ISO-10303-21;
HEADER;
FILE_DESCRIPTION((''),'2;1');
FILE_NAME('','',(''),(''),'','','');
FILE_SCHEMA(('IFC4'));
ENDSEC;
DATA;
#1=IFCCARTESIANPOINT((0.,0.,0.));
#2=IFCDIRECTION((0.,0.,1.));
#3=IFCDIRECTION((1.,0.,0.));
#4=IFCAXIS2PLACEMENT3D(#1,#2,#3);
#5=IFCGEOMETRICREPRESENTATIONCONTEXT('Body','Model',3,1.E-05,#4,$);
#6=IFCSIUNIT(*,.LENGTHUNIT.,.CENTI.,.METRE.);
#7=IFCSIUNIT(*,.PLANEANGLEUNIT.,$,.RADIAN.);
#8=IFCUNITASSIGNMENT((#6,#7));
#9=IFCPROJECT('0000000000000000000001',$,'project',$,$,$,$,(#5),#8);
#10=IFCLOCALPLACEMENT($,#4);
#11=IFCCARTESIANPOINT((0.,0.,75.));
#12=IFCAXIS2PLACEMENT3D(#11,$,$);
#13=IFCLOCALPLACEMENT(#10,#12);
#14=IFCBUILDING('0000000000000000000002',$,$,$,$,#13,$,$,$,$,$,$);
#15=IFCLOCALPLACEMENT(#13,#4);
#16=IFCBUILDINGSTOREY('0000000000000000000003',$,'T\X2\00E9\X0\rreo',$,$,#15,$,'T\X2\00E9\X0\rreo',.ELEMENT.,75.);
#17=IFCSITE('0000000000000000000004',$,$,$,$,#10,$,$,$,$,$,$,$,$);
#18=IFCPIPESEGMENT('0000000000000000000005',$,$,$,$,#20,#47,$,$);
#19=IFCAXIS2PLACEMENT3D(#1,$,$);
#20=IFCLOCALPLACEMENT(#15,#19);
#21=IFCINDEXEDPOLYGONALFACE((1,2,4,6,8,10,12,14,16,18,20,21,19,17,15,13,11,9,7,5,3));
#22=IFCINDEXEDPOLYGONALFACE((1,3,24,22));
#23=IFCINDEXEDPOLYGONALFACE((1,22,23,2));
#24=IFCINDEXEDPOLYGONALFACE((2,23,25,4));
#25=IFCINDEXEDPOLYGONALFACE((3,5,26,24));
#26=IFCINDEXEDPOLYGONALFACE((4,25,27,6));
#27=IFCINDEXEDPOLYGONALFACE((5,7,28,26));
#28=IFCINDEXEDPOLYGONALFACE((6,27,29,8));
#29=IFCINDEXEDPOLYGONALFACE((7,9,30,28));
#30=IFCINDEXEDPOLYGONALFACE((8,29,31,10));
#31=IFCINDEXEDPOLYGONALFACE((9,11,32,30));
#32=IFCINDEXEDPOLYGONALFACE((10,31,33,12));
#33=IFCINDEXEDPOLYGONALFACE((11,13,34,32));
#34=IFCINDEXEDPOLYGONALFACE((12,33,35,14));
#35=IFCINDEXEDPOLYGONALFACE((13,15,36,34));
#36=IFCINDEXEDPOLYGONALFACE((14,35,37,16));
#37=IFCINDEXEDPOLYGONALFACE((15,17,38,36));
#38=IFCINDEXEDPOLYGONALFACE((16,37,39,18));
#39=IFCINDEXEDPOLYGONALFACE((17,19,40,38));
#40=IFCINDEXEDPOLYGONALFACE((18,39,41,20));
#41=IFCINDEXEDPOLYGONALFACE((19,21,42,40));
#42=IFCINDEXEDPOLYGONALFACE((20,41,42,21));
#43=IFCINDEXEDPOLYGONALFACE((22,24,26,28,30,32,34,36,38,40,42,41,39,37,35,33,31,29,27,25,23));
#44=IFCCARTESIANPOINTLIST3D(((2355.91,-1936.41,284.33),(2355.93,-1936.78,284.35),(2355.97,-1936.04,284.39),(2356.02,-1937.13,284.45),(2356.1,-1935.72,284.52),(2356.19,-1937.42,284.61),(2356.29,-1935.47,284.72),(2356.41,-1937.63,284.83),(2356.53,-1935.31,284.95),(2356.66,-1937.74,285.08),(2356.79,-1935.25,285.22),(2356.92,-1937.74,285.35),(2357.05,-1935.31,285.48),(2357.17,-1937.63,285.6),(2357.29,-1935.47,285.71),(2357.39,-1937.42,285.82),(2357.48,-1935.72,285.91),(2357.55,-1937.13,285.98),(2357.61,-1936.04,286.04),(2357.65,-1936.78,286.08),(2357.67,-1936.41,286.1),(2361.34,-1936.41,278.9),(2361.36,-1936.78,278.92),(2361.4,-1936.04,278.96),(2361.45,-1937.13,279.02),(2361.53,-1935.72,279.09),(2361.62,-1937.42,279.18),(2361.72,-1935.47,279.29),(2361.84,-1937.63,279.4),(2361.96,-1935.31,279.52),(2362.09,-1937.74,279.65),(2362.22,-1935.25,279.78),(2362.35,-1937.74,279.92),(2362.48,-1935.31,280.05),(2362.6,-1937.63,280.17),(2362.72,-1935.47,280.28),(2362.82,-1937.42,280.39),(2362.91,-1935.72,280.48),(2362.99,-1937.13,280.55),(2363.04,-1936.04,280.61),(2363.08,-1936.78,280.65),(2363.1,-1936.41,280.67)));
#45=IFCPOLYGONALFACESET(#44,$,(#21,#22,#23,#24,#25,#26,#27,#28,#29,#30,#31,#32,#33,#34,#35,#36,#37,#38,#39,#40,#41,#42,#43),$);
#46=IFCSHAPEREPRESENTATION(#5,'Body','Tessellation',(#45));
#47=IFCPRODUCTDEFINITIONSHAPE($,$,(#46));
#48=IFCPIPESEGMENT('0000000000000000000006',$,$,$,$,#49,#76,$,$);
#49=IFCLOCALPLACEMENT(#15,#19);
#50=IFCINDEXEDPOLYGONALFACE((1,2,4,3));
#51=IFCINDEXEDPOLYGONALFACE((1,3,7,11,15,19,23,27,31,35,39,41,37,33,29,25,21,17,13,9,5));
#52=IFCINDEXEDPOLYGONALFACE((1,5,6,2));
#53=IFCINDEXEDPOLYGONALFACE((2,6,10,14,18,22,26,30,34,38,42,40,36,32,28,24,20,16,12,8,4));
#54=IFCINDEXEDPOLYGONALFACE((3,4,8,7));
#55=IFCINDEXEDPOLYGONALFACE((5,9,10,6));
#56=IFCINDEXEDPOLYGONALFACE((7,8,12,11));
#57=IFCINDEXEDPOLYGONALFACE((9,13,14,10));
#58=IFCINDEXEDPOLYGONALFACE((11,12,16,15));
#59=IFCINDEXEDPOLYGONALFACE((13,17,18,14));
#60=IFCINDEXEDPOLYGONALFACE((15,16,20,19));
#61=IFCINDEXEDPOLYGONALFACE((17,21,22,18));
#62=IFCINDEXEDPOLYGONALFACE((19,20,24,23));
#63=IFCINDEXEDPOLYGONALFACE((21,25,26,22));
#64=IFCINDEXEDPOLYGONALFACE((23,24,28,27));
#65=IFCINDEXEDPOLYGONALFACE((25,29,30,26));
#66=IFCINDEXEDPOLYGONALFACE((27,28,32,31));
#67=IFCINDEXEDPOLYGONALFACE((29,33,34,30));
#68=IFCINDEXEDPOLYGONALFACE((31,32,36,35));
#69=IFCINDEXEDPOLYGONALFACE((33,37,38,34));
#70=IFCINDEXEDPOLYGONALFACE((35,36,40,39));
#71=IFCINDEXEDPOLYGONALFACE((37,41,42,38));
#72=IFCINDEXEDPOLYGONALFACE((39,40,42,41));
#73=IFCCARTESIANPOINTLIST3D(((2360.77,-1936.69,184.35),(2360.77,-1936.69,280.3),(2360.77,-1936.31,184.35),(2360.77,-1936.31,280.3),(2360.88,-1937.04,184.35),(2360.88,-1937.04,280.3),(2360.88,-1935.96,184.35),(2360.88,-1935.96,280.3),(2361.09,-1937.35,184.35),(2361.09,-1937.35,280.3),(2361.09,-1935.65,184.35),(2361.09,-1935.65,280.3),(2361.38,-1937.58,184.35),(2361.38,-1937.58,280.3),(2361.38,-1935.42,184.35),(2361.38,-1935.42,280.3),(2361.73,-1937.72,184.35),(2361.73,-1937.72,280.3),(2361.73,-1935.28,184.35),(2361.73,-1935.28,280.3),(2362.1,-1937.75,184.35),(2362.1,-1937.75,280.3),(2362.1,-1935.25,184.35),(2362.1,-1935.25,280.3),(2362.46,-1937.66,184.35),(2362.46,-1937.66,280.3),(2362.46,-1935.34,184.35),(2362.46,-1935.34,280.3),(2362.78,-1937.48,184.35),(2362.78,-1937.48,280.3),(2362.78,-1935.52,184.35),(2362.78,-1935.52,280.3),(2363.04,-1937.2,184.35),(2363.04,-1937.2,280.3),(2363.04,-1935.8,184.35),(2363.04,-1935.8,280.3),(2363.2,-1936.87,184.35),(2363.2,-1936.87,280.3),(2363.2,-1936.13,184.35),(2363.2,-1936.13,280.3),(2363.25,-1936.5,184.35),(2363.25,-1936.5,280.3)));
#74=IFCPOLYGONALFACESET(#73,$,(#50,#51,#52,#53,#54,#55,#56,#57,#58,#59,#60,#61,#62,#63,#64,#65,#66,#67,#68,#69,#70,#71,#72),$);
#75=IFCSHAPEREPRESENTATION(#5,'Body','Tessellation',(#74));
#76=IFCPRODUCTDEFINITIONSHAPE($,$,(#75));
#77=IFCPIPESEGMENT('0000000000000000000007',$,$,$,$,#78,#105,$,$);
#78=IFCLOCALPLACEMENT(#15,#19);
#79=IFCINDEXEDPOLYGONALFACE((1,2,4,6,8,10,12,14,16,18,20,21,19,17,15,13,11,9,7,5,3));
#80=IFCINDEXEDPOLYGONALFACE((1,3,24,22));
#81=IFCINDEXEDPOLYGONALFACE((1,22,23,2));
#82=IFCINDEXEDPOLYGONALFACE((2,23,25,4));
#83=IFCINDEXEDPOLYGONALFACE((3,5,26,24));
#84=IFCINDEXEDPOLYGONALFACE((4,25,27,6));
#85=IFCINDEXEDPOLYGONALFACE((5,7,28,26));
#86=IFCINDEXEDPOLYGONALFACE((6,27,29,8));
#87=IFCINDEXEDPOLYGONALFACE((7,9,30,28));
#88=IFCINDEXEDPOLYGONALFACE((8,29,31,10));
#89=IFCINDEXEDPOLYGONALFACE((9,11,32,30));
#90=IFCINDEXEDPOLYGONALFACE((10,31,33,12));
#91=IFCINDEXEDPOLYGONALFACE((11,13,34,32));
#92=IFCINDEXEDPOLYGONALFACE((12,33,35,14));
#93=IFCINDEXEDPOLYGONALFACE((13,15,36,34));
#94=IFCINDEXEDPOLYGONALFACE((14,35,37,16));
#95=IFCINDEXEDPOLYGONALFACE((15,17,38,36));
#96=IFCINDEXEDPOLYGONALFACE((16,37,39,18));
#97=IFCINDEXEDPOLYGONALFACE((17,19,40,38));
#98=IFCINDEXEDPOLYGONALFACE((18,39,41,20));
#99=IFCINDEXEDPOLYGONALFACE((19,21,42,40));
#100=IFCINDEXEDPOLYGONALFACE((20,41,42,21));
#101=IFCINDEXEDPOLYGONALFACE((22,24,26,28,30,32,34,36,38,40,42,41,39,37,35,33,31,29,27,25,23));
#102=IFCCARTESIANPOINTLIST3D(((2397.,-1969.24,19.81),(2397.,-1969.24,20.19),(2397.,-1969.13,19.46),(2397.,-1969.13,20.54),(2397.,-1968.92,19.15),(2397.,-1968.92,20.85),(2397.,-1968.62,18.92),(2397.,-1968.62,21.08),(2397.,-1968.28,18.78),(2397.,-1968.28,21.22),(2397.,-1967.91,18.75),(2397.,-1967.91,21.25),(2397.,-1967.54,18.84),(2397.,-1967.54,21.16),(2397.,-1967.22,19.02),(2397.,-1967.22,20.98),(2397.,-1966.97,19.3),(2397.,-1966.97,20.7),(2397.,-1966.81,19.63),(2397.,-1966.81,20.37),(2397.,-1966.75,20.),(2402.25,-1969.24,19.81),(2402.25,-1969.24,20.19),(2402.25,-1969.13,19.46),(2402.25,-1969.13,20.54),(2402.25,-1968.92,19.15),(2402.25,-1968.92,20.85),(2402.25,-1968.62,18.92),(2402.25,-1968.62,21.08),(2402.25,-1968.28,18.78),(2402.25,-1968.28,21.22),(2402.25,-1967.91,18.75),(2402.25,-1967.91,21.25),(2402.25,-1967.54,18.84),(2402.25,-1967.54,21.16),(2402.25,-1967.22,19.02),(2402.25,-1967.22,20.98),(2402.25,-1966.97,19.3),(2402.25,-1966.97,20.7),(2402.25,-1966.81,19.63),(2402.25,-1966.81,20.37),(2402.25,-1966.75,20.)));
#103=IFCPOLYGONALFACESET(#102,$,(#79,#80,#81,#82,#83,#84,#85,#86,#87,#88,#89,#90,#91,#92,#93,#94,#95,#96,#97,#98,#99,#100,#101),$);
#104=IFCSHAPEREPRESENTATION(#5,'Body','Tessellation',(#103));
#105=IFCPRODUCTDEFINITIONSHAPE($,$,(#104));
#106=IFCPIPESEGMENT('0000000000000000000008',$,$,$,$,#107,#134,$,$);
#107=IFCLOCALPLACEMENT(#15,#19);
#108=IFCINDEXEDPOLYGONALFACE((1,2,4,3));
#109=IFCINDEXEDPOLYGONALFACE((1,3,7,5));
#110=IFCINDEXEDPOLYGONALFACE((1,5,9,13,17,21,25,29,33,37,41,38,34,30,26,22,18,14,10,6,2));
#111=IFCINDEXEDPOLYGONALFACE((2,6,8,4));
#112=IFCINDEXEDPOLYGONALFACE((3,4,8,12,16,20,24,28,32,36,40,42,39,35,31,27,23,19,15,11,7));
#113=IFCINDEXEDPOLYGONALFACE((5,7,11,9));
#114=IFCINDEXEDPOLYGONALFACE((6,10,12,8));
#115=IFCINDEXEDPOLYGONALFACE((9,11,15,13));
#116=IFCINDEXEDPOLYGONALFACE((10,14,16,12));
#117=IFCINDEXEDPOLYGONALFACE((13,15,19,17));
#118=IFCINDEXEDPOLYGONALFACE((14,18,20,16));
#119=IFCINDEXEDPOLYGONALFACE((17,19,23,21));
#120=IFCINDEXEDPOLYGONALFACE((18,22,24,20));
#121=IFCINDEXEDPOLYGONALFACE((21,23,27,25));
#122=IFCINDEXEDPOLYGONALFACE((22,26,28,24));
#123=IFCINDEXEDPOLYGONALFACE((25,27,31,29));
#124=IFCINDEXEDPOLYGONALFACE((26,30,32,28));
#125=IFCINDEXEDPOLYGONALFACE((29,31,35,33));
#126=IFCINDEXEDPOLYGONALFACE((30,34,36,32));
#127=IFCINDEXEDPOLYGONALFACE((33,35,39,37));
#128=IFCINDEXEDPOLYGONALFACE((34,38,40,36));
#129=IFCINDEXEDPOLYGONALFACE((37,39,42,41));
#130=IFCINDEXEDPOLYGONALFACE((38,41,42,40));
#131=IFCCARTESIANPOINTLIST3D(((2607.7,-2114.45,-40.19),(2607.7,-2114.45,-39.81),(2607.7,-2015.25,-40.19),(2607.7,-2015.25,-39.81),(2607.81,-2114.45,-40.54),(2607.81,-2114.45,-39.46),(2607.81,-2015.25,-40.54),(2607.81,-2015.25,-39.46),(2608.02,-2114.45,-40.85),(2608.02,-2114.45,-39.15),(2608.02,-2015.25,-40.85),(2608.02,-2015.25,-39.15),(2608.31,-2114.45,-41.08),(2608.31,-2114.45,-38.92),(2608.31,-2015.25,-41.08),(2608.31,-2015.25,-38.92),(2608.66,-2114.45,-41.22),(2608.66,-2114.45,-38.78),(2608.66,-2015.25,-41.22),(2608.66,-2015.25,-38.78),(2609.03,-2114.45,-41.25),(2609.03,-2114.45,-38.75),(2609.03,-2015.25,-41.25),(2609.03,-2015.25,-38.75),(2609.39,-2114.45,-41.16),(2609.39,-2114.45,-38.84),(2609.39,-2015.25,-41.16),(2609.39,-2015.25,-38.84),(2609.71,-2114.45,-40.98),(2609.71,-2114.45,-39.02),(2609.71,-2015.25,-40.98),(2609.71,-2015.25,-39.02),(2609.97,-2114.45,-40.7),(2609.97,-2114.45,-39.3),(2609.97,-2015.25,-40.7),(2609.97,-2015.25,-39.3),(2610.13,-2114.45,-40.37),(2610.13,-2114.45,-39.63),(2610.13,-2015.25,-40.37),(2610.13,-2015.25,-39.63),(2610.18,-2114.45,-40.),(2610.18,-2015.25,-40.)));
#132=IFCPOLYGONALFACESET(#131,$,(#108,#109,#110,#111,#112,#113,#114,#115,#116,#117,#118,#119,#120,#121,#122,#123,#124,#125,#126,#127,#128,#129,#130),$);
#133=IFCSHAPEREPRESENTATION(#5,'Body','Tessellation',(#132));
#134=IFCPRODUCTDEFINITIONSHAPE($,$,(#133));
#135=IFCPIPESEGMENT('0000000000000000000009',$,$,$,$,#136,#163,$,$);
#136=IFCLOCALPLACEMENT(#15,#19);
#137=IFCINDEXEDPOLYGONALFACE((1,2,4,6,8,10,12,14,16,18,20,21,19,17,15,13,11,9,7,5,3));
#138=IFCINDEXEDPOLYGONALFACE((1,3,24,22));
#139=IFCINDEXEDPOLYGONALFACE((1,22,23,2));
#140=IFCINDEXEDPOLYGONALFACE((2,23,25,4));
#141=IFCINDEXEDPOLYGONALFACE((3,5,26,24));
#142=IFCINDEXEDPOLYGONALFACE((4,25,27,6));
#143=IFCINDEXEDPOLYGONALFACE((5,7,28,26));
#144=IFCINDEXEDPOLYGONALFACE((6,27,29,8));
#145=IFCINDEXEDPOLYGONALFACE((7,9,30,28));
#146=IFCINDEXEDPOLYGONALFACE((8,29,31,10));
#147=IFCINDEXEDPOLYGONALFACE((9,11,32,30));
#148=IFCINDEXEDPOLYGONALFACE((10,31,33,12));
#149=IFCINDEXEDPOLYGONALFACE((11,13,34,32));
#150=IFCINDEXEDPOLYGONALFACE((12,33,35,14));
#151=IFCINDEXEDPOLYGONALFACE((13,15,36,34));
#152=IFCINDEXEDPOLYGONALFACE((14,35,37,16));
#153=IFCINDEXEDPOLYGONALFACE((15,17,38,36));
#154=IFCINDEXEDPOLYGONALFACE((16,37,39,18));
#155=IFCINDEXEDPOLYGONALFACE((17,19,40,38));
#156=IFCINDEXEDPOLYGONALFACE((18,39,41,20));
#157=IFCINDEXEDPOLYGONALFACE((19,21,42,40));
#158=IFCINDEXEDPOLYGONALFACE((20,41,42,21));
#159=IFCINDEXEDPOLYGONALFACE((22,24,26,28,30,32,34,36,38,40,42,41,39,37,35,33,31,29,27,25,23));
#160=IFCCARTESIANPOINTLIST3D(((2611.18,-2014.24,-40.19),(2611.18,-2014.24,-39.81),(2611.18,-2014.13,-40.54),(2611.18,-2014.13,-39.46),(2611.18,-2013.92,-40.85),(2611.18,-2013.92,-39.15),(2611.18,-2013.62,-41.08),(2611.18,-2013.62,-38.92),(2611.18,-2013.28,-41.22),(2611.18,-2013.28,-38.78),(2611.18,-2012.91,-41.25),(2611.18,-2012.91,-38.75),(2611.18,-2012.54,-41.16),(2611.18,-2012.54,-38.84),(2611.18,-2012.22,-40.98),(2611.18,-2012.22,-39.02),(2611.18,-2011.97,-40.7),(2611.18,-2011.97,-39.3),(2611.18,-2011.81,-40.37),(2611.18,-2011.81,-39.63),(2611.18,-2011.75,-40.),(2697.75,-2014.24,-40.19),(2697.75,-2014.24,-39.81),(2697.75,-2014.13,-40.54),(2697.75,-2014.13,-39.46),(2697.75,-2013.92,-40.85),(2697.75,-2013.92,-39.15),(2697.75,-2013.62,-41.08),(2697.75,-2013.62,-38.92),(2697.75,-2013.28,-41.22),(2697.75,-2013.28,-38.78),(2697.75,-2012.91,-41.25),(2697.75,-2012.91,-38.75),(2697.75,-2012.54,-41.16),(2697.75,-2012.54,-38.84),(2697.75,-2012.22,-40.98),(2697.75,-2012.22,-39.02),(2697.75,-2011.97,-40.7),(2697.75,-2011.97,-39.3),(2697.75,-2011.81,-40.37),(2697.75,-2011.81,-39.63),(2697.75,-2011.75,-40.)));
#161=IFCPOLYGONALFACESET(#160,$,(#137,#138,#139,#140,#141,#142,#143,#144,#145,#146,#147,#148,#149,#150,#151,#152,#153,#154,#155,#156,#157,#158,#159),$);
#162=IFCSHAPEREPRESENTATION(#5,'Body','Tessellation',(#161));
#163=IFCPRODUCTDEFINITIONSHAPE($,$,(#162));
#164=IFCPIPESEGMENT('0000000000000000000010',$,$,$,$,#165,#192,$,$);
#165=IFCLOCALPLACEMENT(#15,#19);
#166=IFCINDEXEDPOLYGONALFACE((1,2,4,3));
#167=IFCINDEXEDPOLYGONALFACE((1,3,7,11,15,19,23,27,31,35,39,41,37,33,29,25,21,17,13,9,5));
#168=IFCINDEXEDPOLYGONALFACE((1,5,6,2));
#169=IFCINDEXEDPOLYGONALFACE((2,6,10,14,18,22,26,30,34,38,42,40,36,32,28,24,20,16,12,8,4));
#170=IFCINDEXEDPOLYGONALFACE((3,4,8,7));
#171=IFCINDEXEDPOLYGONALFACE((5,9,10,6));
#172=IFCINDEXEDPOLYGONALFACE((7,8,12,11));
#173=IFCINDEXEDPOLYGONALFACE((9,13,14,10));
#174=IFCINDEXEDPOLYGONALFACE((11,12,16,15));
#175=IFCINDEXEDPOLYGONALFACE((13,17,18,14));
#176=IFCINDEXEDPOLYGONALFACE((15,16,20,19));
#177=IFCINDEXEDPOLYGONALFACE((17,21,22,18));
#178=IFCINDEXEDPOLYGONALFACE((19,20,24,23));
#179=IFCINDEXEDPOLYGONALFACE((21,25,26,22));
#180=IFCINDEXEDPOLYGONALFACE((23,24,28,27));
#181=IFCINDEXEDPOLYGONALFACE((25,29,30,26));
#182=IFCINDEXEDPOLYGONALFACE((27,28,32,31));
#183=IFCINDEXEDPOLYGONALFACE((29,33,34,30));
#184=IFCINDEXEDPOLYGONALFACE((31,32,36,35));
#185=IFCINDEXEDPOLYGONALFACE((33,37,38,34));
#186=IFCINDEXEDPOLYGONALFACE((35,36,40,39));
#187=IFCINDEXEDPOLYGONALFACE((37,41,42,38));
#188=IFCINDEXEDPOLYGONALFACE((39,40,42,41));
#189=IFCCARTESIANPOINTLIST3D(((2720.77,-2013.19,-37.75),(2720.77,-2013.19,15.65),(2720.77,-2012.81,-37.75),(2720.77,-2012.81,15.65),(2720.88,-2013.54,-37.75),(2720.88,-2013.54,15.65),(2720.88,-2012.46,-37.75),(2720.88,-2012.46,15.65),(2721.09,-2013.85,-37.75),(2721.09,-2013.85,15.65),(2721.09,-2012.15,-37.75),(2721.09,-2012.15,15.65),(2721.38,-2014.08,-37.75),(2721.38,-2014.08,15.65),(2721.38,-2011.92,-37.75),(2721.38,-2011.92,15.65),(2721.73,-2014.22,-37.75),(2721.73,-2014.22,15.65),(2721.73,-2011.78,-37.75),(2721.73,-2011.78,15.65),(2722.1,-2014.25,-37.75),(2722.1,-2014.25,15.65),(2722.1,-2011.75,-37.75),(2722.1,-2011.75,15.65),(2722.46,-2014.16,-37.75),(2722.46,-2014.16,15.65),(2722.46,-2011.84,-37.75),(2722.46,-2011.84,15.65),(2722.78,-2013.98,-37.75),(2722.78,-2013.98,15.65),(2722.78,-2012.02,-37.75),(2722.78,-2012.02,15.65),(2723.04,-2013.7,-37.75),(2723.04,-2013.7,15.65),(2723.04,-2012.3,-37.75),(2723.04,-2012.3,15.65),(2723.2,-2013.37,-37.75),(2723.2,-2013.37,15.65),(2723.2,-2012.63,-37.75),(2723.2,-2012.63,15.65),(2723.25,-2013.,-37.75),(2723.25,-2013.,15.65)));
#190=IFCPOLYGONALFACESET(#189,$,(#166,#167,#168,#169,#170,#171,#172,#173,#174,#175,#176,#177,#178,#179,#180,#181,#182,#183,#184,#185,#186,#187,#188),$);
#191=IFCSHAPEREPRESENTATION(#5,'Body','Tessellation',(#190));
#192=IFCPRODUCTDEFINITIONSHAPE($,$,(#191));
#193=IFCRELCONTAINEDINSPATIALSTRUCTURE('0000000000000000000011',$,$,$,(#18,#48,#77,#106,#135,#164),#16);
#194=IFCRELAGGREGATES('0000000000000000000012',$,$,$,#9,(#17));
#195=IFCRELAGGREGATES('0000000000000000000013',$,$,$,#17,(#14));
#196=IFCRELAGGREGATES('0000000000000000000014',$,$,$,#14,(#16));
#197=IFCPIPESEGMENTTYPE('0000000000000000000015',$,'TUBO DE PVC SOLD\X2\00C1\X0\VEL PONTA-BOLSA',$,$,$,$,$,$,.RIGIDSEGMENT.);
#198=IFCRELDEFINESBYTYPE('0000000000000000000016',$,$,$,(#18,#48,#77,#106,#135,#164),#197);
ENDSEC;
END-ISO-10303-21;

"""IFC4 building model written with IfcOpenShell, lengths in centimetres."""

from ifc_helpers import new_model, si_unit, frame, origin_with_axes, origin_2d_with_axis, place, context, project, spatial, circle, extrude, type_object, element, save


model = new_model("IFC4")

# Units and contexts
model_context = context("Model", 3, precision=1e-05, world=origin_with_axes(), identifier="Body")
ifc_project = project(units=[si_unit("LENGTHUNIT", "METRE", prefix="CENTI"), si_unit("PLANEANGLEUNIT", "RADIAN")], contexts=[model_context])

# Site, building, storey
site_placement = place(None, origin_with_axes())
site = spatial("IfcSite", under=ifc_project, at=site_placement)
building_placement = place(site_placement, frame((0.0, 0.0, 75.0)))
building = spatial("IfcBuilding", under=site, at=building_placement)
storey_placement = place(building_placement, origin_with_axes())
storey = spatial("IfcBuildingStorey", under=building, at=storey_placement, Name="Térreo", LongName="Térreo", CompositionType="ELEMENT", Elevation=75.0)

# Pipe segments
pipe_segment_type_1 = type_object("IfcPipeSegmentType", Name="TUBO DE PVC SOLDÁVEL PONTA-BOLSA", PredefinedType="RIGIDSEGMENT")
pipe_segment_1_placement = place(storey_placement, frame((2359.5, -1936.5, 286.1), z_axis=(0.0, 0.0, 1.0), x_axis=(1.0, 0.0, 0.0)))
element("IfcPipeSegment", 1, at=pipe_segment_1_placement, inside=storey, type_object=pipe_segment_type_1, context=model_context, shape_type="SolidModel", body=[
    extrude(circle(Radius=1.25, at=origin_2d_with_axis()), frame((-2.72, 0.0, -0.88), z_axis=(0.707107, 0.0, -0.707107), x_axis=(0.0, 1.0, 0.0)), (0.0, 0.0, 1.0), 7.68),
])
pipe_segment_2_placement = place(storey_placement, frame((2362.0, -1936.5, 280.3), z_axis=(0.0, 0.0, 1.0), x_axis=(1.0, 0.0, 0.0)))
element("IfcPipeSegment", 2, at=pipe_segment_2_placement, inside=storey, type_object=pipe_segment_type_1, context=model_context, shape_type="SolidModel", body=[
    extrude(circle(Radius=1.25, at=origin_2d_with_axis()), frame((0.0, 0.0, 0.0), z_axis=(0.0, 0.0, -1.0), x_axis=(1.0, 0.0, 0.0)), (0.0, 0.0, 1.0), 95.95),
])
pipe_segment_3_placement = place(storey_placement, frame((2399.63, -1968.0, 21.25), z_axis=(0.0, 0.0, 1.0), x_axis=(1.0, 0.0, 0.0)))
element("IfcPipeSegment", 3, at=pipe_segment_3_placement, inside=storey, type_object=pipe_segment_type_1, context=model_context, shape_type="SolidModel", body=[
    extrude(circle(Radius=1.25, at=origin_2d_with_axis()), frame((2.62, 0.0, -1.25), z_axis=(-1.0, 0.0, 0.0), x_axis=(0.0, 1.0, 0.0)), (0.0, 0.0, 1.0), 5.25),
])
pipe_segment_4_placement = place(storey_placement, frame((2608.93, -2064.85, -38.75), z_axis=(0.0, 0.0, 1.0), x_axis=(1.0, 0.0, 0.0)))
element("IfcPipeSegment", 4, at=pipe_segment_4_placement, inside=storey, type_object=pipe_segment_type_1, context=model_context, shape_type="SolidModel", body=[
    extrude(circle(Radius=1.25, at=origin_2d_with_axis()), frame((0.0, 49.6, -1.25), z_axis=(0.0, -1.0, 0.0), x_axis=(1.0, 0.0, 0.0)), (0.0, 0.0, 1.0), 99.2),
])
pipe_segment_5_placement = place(storey_placement, frame((2654.47, -2013.0, -38.75), z_axis=(0.0, 0.0, 1.0), x_axis=(1.0, 0.0, 0.0)))
element("IfcPipeSegment", 5, at=pipe_segment_5_placement, inside=storey, type_object=pipe_segment_type_1, context=model_context, shape_type="SolidModel", body=[
    extrude(circle(Radius=1.25, at=origin_2d_with_axis()), frame((43.29, 0.0, -1.25), z_axis=(-1.0, 0.0, 0.0), x_axis=(0.0, 1.0, 0.0)), (0.0, 0.0, 1.0), 86.57),
])
pipe_segment_6_placement = place(storey_placement, frame((2722.0, -2013.0, 15.65), z_axis=(0.0, 0.0, 1.0), x_axis=(1.0, 0.0, 0.0)))
element("IfcPipeSegment", 6, at=pipe_segment_6_placement, inside=storey, type_object=pipe_segment_type_1, context=model_context, shape_type="SolidModel", body=[
    extrude(circle(Radius=1.25, at=origin_2d_with_axis()), frame((0.0, 0.0, 0.0), z_axis=(0.0, 0.0, -1.0), x_axis=(1.0, 0.0, 0.0)), (0.0, 0.0, 1.0), 53.4),
])

save(model, "model.ifc")
